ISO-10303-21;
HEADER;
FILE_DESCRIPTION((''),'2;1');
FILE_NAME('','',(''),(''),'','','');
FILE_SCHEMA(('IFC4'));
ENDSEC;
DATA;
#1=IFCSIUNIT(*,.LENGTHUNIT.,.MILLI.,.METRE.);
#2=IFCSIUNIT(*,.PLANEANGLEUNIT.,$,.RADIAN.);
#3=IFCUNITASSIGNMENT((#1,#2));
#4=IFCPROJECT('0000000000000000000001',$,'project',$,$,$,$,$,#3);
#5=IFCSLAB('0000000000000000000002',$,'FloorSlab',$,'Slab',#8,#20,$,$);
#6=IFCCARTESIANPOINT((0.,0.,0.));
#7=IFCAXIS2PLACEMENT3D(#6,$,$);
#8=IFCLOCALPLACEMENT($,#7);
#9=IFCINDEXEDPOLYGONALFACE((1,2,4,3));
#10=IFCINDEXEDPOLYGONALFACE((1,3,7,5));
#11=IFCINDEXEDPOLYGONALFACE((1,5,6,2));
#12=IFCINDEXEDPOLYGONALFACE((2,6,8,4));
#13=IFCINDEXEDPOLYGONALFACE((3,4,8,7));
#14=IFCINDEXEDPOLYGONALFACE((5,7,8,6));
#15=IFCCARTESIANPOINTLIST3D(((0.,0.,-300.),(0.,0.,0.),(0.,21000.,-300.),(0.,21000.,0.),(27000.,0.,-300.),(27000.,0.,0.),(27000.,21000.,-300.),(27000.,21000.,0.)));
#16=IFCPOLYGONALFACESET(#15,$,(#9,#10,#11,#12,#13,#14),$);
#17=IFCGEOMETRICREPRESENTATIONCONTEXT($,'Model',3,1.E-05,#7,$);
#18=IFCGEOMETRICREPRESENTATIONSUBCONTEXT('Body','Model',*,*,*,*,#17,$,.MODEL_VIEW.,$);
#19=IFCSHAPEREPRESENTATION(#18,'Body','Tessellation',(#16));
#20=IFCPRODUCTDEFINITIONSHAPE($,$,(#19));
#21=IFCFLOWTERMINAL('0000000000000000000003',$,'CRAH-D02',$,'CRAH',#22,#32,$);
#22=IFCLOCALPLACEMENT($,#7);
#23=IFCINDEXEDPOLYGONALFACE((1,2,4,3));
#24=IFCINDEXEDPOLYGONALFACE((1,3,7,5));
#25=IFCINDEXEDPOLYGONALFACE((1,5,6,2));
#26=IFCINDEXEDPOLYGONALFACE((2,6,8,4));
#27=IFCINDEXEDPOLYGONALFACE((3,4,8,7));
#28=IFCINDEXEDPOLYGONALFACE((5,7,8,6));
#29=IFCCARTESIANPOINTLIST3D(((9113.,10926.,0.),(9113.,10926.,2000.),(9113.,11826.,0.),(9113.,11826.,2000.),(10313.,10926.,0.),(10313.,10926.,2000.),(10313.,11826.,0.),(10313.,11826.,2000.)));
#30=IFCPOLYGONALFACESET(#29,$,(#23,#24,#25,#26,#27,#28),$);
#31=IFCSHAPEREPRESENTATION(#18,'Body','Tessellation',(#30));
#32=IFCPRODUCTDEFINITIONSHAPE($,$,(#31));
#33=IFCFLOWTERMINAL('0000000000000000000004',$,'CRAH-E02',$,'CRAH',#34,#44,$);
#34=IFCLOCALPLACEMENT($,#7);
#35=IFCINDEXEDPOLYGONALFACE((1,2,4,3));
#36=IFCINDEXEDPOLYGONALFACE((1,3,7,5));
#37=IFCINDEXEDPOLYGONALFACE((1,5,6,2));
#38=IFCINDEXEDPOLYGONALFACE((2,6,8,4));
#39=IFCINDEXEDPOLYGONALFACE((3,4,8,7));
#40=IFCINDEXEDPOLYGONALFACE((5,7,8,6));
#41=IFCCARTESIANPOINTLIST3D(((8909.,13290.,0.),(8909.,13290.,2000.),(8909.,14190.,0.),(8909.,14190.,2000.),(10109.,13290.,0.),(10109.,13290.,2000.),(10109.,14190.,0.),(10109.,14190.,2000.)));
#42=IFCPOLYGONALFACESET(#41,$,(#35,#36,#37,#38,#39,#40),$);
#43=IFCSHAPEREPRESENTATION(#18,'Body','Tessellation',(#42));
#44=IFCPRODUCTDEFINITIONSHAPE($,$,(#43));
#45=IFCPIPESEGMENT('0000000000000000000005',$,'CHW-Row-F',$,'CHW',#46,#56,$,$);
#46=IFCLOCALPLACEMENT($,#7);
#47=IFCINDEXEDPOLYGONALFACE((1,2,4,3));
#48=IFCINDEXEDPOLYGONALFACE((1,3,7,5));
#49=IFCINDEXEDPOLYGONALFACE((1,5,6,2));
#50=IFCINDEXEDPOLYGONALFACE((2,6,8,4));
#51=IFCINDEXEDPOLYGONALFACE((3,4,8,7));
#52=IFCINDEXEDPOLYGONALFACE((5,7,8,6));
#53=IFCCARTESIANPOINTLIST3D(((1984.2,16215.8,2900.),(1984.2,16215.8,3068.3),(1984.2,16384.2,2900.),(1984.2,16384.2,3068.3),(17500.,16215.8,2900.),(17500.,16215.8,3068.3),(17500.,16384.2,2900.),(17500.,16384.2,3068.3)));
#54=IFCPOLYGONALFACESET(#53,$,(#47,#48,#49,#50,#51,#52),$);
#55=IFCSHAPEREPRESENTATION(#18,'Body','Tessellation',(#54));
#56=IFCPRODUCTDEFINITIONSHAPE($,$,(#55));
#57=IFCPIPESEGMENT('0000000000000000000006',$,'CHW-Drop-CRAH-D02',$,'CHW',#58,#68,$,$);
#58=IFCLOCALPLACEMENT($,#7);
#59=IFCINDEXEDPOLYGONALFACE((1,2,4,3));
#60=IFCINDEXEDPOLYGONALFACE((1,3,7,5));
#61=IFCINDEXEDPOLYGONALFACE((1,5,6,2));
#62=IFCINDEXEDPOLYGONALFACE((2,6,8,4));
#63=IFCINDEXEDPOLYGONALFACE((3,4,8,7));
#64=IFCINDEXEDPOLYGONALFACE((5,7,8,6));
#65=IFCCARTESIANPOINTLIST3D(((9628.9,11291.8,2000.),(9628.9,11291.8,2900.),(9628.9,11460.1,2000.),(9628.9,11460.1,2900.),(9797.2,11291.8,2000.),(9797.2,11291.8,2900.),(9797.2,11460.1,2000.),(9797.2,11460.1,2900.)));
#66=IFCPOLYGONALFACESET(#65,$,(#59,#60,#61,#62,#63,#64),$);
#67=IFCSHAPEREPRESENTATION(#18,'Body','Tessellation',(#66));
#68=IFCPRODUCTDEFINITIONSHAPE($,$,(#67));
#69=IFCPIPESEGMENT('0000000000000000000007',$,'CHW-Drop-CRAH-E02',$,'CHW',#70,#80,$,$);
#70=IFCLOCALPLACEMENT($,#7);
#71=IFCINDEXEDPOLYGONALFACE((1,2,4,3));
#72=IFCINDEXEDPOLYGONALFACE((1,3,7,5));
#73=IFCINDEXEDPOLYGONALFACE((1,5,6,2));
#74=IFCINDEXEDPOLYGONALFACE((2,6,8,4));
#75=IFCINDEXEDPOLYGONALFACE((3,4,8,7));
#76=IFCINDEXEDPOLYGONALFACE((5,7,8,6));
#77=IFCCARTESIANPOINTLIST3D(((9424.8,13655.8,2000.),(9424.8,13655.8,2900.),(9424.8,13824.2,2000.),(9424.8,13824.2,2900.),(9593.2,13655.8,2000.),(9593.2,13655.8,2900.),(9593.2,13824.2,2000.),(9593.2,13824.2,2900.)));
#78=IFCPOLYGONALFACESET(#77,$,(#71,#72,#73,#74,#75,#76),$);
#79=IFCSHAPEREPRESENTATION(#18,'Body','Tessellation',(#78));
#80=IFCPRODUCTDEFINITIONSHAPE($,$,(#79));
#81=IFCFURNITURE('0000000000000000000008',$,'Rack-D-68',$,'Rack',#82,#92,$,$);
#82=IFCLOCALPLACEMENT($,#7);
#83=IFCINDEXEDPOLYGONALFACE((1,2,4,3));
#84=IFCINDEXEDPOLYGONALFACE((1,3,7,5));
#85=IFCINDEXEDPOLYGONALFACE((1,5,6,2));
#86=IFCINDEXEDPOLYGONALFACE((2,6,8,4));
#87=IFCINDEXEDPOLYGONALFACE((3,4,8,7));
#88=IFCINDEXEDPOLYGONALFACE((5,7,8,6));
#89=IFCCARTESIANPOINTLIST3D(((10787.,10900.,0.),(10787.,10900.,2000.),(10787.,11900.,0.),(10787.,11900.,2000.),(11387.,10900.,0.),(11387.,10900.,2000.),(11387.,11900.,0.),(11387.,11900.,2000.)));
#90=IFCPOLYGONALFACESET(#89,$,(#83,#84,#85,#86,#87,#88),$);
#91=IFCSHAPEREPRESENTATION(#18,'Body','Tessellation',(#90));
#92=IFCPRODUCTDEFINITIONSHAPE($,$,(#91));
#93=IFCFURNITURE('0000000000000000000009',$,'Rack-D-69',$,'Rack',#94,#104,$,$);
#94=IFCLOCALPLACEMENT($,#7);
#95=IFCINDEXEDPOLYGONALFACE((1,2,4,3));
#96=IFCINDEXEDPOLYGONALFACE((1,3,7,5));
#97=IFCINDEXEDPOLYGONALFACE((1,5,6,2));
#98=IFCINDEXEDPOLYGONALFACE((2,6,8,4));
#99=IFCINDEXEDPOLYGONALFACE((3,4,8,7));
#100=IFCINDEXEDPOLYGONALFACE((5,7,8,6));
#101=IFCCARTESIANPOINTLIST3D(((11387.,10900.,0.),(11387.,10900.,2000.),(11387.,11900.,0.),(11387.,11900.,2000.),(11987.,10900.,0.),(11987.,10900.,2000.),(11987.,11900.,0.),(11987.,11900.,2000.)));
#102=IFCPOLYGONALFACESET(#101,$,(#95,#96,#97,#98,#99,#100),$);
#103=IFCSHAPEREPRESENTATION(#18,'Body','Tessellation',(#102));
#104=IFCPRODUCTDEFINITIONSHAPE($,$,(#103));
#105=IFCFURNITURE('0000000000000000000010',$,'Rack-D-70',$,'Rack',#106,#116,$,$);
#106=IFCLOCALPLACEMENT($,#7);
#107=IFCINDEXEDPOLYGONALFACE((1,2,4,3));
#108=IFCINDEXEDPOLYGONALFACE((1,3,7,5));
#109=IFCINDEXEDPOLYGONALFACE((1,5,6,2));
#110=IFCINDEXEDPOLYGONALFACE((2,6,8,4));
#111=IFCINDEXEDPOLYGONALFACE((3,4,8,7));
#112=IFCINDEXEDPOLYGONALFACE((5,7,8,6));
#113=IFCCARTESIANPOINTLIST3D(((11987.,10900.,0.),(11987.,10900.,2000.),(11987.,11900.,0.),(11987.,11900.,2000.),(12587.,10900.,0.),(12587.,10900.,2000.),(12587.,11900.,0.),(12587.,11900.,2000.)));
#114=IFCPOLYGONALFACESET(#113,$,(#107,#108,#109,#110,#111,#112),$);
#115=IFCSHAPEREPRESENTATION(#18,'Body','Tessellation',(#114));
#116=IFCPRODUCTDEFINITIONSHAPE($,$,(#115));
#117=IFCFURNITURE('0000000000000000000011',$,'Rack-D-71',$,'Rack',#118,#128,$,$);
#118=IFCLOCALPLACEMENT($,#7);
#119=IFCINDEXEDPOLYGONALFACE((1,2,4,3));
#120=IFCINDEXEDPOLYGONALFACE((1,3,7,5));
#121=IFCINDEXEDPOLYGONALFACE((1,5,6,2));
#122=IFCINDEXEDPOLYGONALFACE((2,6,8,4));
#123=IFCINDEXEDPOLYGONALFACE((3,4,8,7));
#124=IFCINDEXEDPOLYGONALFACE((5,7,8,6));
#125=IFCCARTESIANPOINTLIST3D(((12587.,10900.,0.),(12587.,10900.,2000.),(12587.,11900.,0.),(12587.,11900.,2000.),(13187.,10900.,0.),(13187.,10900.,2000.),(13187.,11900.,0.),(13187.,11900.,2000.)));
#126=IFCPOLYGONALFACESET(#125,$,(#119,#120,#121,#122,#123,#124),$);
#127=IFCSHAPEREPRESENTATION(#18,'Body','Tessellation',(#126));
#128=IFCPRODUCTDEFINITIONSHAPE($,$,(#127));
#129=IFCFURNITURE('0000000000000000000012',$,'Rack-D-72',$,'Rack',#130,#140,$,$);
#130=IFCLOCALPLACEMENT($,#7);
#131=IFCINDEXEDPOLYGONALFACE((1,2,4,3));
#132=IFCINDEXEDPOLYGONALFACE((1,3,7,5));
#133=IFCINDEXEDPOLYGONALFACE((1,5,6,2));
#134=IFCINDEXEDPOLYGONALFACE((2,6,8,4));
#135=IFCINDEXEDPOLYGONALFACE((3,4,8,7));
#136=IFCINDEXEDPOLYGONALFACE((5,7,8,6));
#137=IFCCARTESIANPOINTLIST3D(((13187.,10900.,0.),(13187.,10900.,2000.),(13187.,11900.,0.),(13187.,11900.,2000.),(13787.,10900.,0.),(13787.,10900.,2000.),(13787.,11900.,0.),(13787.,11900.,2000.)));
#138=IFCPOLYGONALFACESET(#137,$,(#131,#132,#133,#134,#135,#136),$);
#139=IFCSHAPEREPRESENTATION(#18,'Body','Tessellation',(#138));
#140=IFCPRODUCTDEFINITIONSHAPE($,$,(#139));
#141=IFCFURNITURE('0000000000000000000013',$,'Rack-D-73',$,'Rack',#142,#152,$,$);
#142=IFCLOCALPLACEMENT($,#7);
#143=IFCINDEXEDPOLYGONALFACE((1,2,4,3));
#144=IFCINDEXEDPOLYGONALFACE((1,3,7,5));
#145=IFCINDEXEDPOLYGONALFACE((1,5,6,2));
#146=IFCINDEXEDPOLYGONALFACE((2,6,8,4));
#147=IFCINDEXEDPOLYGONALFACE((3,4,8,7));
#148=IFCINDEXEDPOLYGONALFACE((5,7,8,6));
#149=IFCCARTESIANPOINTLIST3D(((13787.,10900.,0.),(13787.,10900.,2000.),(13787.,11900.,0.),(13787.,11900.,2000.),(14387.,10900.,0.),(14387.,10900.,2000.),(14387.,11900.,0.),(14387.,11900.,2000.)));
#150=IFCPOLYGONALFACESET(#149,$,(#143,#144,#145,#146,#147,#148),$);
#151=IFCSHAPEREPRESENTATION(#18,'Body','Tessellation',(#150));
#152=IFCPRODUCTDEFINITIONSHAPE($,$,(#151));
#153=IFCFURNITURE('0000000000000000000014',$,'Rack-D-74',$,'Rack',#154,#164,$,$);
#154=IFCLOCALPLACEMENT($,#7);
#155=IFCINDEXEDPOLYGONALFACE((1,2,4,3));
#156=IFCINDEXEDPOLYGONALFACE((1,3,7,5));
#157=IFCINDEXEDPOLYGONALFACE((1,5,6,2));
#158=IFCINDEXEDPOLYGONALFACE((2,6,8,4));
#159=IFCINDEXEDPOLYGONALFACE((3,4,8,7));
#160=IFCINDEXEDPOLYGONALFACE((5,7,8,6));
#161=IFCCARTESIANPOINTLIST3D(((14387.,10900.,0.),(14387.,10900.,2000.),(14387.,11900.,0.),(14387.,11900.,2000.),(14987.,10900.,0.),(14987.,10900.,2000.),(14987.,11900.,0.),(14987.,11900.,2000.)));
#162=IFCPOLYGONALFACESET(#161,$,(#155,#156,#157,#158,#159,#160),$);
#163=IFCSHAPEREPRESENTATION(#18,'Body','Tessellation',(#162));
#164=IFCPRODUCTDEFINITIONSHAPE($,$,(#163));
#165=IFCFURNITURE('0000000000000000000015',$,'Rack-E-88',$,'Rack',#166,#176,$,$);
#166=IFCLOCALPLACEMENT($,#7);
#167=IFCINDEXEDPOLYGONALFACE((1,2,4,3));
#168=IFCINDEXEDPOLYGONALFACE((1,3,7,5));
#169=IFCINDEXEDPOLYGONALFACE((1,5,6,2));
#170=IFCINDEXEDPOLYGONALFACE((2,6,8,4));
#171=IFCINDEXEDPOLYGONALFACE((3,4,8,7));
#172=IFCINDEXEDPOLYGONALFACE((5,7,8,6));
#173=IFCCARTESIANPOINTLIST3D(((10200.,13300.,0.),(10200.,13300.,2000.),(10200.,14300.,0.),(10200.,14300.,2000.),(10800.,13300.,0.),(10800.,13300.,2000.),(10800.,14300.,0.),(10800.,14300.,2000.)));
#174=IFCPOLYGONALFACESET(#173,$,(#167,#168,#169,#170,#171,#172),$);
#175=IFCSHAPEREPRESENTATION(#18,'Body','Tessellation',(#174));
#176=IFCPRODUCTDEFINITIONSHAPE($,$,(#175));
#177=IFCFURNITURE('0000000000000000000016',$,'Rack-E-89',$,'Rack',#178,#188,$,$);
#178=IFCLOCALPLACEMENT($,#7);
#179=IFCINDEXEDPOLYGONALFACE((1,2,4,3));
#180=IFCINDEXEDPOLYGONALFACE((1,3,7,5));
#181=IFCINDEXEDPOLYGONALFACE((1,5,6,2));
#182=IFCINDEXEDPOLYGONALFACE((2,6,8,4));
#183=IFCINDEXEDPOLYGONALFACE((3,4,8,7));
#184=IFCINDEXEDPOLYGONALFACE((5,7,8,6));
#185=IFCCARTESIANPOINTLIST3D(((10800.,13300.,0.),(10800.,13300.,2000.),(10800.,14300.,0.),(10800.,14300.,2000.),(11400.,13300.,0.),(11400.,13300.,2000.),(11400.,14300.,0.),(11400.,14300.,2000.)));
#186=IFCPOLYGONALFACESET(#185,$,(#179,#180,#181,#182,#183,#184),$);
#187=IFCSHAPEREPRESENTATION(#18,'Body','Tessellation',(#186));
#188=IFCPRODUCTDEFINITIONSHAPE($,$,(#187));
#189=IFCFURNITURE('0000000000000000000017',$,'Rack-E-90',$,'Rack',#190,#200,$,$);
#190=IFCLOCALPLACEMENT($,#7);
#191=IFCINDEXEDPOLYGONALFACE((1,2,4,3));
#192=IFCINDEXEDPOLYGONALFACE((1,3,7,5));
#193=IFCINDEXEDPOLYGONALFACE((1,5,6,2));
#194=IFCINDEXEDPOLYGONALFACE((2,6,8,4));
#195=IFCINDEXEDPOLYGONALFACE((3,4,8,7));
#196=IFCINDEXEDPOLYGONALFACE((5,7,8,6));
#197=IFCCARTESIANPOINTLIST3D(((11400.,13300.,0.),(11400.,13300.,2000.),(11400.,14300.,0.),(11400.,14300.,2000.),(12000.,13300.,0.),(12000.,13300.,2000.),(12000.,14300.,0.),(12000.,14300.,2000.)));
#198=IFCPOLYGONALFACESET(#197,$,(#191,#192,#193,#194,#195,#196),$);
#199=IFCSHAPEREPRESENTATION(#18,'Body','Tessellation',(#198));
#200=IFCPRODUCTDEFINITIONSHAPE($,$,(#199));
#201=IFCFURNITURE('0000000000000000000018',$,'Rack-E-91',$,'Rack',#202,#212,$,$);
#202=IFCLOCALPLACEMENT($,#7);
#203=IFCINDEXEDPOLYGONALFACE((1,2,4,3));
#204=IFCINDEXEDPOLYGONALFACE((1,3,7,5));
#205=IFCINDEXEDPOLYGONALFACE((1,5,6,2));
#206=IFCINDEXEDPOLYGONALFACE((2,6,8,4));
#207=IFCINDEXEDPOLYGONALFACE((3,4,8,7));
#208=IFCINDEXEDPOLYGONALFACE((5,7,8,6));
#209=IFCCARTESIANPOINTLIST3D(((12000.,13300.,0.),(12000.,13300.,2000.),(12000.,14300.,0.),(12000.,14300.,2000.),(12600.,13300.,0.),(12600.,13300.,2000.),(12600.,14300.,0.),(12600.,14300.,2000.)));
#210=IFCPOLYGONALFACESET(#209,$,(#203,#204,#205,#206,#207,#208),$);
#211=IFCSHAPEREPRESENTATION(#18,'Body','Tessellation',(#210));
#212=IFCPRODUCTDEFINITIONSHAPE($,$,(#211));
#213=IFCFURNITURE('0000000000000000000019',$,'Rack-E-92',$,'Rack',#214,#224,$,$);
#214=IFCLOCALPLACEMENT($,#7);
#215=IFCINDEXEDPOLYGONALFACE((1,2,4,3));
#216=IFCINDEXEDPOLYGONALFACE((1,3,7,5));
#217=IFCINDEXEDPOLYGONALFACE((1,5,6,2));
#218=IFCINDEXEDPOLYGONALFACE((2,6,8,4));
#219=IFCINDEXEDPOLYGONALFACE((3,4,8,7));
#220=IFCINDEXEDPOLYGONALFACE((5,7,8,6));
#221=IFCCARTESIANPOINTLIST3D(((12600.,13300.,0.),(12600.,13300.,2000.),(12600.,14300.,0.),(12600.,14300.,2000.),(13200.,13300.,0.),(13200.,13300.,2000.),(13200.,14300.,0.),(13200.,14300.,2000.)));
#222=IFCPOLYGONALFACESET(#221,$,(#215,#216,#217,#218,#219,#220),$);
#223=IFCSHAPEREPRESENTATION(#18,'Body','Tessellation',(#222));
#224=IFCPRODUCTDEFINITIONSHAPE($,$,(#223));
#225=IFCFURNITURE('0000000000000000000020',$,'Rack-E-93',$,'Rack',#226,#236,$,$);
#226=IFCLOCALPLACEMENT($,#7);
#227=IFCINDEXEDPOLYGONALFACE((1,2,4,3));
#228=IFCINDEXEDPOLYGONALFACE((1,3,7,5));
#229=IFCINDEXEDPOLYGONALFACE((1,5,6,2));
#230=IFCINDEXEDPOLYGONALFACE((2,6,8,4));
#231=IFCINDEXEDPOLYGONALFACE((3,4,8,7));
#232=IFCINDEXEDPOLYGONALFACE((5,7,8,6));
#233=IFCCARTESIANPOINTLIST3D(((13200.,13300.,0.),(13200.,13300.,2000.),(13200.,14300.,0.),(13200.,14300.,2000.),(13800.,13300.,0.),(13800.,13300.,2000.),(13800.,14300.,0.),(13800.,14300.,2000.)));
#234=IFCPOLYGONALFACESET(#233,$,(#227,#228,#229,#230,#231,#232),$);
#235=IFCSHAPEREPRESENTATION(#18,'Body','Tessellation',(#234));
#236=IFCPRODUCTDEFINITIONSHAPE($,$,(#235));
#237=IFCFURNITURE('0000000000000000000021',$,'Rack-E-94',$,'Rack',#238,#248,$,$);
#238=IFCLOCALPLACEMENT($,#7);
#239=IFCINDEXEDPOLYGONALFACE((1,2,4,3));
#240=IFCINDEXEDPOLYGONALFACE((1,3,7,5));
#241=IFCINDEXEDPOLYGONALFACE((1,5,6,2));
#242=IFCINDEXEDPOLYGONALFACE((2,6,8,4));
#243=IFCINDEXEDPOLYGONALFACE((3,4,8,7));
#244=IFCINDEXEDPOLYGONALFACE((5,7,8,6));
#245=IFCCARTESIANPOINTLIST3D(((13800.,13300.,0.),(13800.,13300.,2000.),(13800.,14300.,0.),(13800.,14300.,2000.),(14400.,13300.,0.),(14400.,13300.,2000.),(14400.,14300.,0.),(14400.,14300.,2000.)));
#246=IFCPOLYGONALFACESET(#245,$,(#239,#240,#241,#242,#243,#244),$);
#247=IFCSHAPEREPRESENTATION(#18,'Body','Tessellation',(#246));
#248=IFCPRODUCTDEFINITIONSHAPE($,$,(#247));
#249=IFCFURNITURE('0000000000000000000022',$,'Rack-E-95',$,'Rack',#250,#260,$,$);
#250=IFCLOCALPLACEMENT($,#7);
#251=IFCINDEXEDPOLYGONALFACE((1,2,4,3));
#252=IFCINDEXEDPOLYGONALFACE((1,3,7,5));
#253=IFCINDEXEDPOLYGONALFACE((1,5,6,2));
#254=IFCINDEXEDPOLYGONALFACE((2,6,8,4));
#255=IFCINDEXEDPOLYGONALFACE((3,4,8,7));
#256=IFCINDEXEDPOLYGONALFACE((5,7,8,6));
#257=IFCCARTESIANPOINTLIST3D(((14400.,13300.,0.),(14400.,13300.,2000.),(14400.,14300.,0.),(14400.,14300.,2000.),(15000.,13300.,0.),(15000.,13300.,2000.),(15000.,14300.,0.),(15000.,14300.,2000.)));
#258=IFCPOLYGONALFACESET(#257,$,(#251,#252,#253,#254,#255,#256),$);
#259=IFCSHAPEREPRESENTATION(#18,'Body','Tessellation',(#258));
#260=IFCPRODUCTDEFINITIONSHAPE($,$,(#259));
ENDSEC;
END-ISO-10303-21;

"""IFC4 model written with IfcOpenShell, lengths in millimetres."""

from ifc_helpers import new_model, si_unit, frame, origin, place, context, subcontext, project, rectangle, extrude, element, save


model = new_model("IFC4")

# Units and contexts
model_context = context("Model", 3, precision=1e-05, world=origin())
body_context = subcontext(model_context, "Body", "Model", "MODEL_VIEW")
ifc_project = project(units=[si_unit("LENGTHUNIT", "METRE", prefix="MILLI"), si_unit("PLANEANGLEUNIT", "RADIAN")])

# Slab
slab_placement = place(None, frame((13500.0, 10500.0, -300.0)))
element("IfcSlab", 1, at=slab_placement, Name="FloorSlab", ObjectType="Slab", context=body_context, shape_type="SweptSolid", body=[
    extrude(rectangle(XDim=27000.0, YDim=21000.0), None, (0.0, 0.0, 1.0), 300.0),
])

# Flow terminals
for number, where, name in (
    (2, (9713.0, 11376.0, 0.0), "CRAH-D02"),
    (3, (9509.0, 13740.0, 0.0), "CRAH-E02"),
):
    element("IfcFlowTerminal", number, at=place(None, frame(where)), Name=name, ObjectType="CRAH", context=body_context, shape_type="SweptSolid", body=[
        extrude(rectangle(XDim=1200.0, YDim=900.0), None, (0.0, 0.0, 1.0), 2000.0),
    ])

# Pipe segments
pipe_segment_placement = place(None, frame((9742.1, 16300.0, 2900.0)))
element("IfcPipeSegment", 4, at=pipe_segment_placement, Name="CHW-Row-F", ObjectType="CHW", context=body_context, shape_type="SweptSolid", body=[
    extrude(rectangle(XDim=15515.9, YDim=168.3), None, (0.0, 0.0, 1.0), 168.3),
])
for number, where, name in (
    (5, (9713.0, 11376.0, 2000.0), "CHW-Drop-CRAH-D02"),
    (6, (9509.0, 13740.0, 2000.0), "CHW-Drop-CRAH-E02"),
):
    element("IfcPipeSegment", number, at=place(None, frame(where)), Name=name, ObjectType="CHW", context=body_context, shape_type="SweptSolid", body=[
        extrude(rectangle(XDim=168.3, YDim=168.3), None, (0.0, 0.0, 1.0), 900.0),
    ])

# Furniture
for number, where, name in (
    (7, (11087.0, 11400.0, 0.0), "Rack-D-68"),
    (8, (11687.0, 11400.0, 0.0), "Rack-D-69"),
    (9, (12287.0, 11400.0, 0.0), "Rack-D-70"),
    (10, (12887.0, 11400.0, 0.0), "Rack-D-71"),
    (11, (13487.0, 11400.0, 0.0), "Rack-D-72"),
    (12, (14087.0, 11400.0, 0.0), "Rack-D-73"),
    (13, (14687.0, 11400.0, 0.0), "Rack-D-74"),
    (14, (10500.0, 13800.0, 0.0), "Rack-E-88"),
    (15, (11100.0, 13800.0, 0.0), "Rack-E-89"),
    (16, (11700.0, 13800.0, 0.0), "Rack-E-90"),
    (17, (12300.0, 13800.0, 0.0), "Rack-E-91"),
    (18, (12900.0, 13800.0, 0.0), "Rack-E-92"),
    (19, (13500.0, 13800.0, 0.0), "Rack-E-93"),
    (20, (14100.0, 13800.0, 0.0), "Rack-E-94"),
    (21, (14700.0, 13800.0, 0.0), "Rack-E-95"),
):
    element("IfcFurniture", number, at=place(None, frame(where)), Name=name, ObjectType="Rack", context=body_context, shape_type="SweptSolid", body=[
        extrude(rectangle(XDim=600.0, YDim=1000.0), None, (0.0, 0.0, 1.0), 2000.0),
    ])

save(model, "model.ifc")
